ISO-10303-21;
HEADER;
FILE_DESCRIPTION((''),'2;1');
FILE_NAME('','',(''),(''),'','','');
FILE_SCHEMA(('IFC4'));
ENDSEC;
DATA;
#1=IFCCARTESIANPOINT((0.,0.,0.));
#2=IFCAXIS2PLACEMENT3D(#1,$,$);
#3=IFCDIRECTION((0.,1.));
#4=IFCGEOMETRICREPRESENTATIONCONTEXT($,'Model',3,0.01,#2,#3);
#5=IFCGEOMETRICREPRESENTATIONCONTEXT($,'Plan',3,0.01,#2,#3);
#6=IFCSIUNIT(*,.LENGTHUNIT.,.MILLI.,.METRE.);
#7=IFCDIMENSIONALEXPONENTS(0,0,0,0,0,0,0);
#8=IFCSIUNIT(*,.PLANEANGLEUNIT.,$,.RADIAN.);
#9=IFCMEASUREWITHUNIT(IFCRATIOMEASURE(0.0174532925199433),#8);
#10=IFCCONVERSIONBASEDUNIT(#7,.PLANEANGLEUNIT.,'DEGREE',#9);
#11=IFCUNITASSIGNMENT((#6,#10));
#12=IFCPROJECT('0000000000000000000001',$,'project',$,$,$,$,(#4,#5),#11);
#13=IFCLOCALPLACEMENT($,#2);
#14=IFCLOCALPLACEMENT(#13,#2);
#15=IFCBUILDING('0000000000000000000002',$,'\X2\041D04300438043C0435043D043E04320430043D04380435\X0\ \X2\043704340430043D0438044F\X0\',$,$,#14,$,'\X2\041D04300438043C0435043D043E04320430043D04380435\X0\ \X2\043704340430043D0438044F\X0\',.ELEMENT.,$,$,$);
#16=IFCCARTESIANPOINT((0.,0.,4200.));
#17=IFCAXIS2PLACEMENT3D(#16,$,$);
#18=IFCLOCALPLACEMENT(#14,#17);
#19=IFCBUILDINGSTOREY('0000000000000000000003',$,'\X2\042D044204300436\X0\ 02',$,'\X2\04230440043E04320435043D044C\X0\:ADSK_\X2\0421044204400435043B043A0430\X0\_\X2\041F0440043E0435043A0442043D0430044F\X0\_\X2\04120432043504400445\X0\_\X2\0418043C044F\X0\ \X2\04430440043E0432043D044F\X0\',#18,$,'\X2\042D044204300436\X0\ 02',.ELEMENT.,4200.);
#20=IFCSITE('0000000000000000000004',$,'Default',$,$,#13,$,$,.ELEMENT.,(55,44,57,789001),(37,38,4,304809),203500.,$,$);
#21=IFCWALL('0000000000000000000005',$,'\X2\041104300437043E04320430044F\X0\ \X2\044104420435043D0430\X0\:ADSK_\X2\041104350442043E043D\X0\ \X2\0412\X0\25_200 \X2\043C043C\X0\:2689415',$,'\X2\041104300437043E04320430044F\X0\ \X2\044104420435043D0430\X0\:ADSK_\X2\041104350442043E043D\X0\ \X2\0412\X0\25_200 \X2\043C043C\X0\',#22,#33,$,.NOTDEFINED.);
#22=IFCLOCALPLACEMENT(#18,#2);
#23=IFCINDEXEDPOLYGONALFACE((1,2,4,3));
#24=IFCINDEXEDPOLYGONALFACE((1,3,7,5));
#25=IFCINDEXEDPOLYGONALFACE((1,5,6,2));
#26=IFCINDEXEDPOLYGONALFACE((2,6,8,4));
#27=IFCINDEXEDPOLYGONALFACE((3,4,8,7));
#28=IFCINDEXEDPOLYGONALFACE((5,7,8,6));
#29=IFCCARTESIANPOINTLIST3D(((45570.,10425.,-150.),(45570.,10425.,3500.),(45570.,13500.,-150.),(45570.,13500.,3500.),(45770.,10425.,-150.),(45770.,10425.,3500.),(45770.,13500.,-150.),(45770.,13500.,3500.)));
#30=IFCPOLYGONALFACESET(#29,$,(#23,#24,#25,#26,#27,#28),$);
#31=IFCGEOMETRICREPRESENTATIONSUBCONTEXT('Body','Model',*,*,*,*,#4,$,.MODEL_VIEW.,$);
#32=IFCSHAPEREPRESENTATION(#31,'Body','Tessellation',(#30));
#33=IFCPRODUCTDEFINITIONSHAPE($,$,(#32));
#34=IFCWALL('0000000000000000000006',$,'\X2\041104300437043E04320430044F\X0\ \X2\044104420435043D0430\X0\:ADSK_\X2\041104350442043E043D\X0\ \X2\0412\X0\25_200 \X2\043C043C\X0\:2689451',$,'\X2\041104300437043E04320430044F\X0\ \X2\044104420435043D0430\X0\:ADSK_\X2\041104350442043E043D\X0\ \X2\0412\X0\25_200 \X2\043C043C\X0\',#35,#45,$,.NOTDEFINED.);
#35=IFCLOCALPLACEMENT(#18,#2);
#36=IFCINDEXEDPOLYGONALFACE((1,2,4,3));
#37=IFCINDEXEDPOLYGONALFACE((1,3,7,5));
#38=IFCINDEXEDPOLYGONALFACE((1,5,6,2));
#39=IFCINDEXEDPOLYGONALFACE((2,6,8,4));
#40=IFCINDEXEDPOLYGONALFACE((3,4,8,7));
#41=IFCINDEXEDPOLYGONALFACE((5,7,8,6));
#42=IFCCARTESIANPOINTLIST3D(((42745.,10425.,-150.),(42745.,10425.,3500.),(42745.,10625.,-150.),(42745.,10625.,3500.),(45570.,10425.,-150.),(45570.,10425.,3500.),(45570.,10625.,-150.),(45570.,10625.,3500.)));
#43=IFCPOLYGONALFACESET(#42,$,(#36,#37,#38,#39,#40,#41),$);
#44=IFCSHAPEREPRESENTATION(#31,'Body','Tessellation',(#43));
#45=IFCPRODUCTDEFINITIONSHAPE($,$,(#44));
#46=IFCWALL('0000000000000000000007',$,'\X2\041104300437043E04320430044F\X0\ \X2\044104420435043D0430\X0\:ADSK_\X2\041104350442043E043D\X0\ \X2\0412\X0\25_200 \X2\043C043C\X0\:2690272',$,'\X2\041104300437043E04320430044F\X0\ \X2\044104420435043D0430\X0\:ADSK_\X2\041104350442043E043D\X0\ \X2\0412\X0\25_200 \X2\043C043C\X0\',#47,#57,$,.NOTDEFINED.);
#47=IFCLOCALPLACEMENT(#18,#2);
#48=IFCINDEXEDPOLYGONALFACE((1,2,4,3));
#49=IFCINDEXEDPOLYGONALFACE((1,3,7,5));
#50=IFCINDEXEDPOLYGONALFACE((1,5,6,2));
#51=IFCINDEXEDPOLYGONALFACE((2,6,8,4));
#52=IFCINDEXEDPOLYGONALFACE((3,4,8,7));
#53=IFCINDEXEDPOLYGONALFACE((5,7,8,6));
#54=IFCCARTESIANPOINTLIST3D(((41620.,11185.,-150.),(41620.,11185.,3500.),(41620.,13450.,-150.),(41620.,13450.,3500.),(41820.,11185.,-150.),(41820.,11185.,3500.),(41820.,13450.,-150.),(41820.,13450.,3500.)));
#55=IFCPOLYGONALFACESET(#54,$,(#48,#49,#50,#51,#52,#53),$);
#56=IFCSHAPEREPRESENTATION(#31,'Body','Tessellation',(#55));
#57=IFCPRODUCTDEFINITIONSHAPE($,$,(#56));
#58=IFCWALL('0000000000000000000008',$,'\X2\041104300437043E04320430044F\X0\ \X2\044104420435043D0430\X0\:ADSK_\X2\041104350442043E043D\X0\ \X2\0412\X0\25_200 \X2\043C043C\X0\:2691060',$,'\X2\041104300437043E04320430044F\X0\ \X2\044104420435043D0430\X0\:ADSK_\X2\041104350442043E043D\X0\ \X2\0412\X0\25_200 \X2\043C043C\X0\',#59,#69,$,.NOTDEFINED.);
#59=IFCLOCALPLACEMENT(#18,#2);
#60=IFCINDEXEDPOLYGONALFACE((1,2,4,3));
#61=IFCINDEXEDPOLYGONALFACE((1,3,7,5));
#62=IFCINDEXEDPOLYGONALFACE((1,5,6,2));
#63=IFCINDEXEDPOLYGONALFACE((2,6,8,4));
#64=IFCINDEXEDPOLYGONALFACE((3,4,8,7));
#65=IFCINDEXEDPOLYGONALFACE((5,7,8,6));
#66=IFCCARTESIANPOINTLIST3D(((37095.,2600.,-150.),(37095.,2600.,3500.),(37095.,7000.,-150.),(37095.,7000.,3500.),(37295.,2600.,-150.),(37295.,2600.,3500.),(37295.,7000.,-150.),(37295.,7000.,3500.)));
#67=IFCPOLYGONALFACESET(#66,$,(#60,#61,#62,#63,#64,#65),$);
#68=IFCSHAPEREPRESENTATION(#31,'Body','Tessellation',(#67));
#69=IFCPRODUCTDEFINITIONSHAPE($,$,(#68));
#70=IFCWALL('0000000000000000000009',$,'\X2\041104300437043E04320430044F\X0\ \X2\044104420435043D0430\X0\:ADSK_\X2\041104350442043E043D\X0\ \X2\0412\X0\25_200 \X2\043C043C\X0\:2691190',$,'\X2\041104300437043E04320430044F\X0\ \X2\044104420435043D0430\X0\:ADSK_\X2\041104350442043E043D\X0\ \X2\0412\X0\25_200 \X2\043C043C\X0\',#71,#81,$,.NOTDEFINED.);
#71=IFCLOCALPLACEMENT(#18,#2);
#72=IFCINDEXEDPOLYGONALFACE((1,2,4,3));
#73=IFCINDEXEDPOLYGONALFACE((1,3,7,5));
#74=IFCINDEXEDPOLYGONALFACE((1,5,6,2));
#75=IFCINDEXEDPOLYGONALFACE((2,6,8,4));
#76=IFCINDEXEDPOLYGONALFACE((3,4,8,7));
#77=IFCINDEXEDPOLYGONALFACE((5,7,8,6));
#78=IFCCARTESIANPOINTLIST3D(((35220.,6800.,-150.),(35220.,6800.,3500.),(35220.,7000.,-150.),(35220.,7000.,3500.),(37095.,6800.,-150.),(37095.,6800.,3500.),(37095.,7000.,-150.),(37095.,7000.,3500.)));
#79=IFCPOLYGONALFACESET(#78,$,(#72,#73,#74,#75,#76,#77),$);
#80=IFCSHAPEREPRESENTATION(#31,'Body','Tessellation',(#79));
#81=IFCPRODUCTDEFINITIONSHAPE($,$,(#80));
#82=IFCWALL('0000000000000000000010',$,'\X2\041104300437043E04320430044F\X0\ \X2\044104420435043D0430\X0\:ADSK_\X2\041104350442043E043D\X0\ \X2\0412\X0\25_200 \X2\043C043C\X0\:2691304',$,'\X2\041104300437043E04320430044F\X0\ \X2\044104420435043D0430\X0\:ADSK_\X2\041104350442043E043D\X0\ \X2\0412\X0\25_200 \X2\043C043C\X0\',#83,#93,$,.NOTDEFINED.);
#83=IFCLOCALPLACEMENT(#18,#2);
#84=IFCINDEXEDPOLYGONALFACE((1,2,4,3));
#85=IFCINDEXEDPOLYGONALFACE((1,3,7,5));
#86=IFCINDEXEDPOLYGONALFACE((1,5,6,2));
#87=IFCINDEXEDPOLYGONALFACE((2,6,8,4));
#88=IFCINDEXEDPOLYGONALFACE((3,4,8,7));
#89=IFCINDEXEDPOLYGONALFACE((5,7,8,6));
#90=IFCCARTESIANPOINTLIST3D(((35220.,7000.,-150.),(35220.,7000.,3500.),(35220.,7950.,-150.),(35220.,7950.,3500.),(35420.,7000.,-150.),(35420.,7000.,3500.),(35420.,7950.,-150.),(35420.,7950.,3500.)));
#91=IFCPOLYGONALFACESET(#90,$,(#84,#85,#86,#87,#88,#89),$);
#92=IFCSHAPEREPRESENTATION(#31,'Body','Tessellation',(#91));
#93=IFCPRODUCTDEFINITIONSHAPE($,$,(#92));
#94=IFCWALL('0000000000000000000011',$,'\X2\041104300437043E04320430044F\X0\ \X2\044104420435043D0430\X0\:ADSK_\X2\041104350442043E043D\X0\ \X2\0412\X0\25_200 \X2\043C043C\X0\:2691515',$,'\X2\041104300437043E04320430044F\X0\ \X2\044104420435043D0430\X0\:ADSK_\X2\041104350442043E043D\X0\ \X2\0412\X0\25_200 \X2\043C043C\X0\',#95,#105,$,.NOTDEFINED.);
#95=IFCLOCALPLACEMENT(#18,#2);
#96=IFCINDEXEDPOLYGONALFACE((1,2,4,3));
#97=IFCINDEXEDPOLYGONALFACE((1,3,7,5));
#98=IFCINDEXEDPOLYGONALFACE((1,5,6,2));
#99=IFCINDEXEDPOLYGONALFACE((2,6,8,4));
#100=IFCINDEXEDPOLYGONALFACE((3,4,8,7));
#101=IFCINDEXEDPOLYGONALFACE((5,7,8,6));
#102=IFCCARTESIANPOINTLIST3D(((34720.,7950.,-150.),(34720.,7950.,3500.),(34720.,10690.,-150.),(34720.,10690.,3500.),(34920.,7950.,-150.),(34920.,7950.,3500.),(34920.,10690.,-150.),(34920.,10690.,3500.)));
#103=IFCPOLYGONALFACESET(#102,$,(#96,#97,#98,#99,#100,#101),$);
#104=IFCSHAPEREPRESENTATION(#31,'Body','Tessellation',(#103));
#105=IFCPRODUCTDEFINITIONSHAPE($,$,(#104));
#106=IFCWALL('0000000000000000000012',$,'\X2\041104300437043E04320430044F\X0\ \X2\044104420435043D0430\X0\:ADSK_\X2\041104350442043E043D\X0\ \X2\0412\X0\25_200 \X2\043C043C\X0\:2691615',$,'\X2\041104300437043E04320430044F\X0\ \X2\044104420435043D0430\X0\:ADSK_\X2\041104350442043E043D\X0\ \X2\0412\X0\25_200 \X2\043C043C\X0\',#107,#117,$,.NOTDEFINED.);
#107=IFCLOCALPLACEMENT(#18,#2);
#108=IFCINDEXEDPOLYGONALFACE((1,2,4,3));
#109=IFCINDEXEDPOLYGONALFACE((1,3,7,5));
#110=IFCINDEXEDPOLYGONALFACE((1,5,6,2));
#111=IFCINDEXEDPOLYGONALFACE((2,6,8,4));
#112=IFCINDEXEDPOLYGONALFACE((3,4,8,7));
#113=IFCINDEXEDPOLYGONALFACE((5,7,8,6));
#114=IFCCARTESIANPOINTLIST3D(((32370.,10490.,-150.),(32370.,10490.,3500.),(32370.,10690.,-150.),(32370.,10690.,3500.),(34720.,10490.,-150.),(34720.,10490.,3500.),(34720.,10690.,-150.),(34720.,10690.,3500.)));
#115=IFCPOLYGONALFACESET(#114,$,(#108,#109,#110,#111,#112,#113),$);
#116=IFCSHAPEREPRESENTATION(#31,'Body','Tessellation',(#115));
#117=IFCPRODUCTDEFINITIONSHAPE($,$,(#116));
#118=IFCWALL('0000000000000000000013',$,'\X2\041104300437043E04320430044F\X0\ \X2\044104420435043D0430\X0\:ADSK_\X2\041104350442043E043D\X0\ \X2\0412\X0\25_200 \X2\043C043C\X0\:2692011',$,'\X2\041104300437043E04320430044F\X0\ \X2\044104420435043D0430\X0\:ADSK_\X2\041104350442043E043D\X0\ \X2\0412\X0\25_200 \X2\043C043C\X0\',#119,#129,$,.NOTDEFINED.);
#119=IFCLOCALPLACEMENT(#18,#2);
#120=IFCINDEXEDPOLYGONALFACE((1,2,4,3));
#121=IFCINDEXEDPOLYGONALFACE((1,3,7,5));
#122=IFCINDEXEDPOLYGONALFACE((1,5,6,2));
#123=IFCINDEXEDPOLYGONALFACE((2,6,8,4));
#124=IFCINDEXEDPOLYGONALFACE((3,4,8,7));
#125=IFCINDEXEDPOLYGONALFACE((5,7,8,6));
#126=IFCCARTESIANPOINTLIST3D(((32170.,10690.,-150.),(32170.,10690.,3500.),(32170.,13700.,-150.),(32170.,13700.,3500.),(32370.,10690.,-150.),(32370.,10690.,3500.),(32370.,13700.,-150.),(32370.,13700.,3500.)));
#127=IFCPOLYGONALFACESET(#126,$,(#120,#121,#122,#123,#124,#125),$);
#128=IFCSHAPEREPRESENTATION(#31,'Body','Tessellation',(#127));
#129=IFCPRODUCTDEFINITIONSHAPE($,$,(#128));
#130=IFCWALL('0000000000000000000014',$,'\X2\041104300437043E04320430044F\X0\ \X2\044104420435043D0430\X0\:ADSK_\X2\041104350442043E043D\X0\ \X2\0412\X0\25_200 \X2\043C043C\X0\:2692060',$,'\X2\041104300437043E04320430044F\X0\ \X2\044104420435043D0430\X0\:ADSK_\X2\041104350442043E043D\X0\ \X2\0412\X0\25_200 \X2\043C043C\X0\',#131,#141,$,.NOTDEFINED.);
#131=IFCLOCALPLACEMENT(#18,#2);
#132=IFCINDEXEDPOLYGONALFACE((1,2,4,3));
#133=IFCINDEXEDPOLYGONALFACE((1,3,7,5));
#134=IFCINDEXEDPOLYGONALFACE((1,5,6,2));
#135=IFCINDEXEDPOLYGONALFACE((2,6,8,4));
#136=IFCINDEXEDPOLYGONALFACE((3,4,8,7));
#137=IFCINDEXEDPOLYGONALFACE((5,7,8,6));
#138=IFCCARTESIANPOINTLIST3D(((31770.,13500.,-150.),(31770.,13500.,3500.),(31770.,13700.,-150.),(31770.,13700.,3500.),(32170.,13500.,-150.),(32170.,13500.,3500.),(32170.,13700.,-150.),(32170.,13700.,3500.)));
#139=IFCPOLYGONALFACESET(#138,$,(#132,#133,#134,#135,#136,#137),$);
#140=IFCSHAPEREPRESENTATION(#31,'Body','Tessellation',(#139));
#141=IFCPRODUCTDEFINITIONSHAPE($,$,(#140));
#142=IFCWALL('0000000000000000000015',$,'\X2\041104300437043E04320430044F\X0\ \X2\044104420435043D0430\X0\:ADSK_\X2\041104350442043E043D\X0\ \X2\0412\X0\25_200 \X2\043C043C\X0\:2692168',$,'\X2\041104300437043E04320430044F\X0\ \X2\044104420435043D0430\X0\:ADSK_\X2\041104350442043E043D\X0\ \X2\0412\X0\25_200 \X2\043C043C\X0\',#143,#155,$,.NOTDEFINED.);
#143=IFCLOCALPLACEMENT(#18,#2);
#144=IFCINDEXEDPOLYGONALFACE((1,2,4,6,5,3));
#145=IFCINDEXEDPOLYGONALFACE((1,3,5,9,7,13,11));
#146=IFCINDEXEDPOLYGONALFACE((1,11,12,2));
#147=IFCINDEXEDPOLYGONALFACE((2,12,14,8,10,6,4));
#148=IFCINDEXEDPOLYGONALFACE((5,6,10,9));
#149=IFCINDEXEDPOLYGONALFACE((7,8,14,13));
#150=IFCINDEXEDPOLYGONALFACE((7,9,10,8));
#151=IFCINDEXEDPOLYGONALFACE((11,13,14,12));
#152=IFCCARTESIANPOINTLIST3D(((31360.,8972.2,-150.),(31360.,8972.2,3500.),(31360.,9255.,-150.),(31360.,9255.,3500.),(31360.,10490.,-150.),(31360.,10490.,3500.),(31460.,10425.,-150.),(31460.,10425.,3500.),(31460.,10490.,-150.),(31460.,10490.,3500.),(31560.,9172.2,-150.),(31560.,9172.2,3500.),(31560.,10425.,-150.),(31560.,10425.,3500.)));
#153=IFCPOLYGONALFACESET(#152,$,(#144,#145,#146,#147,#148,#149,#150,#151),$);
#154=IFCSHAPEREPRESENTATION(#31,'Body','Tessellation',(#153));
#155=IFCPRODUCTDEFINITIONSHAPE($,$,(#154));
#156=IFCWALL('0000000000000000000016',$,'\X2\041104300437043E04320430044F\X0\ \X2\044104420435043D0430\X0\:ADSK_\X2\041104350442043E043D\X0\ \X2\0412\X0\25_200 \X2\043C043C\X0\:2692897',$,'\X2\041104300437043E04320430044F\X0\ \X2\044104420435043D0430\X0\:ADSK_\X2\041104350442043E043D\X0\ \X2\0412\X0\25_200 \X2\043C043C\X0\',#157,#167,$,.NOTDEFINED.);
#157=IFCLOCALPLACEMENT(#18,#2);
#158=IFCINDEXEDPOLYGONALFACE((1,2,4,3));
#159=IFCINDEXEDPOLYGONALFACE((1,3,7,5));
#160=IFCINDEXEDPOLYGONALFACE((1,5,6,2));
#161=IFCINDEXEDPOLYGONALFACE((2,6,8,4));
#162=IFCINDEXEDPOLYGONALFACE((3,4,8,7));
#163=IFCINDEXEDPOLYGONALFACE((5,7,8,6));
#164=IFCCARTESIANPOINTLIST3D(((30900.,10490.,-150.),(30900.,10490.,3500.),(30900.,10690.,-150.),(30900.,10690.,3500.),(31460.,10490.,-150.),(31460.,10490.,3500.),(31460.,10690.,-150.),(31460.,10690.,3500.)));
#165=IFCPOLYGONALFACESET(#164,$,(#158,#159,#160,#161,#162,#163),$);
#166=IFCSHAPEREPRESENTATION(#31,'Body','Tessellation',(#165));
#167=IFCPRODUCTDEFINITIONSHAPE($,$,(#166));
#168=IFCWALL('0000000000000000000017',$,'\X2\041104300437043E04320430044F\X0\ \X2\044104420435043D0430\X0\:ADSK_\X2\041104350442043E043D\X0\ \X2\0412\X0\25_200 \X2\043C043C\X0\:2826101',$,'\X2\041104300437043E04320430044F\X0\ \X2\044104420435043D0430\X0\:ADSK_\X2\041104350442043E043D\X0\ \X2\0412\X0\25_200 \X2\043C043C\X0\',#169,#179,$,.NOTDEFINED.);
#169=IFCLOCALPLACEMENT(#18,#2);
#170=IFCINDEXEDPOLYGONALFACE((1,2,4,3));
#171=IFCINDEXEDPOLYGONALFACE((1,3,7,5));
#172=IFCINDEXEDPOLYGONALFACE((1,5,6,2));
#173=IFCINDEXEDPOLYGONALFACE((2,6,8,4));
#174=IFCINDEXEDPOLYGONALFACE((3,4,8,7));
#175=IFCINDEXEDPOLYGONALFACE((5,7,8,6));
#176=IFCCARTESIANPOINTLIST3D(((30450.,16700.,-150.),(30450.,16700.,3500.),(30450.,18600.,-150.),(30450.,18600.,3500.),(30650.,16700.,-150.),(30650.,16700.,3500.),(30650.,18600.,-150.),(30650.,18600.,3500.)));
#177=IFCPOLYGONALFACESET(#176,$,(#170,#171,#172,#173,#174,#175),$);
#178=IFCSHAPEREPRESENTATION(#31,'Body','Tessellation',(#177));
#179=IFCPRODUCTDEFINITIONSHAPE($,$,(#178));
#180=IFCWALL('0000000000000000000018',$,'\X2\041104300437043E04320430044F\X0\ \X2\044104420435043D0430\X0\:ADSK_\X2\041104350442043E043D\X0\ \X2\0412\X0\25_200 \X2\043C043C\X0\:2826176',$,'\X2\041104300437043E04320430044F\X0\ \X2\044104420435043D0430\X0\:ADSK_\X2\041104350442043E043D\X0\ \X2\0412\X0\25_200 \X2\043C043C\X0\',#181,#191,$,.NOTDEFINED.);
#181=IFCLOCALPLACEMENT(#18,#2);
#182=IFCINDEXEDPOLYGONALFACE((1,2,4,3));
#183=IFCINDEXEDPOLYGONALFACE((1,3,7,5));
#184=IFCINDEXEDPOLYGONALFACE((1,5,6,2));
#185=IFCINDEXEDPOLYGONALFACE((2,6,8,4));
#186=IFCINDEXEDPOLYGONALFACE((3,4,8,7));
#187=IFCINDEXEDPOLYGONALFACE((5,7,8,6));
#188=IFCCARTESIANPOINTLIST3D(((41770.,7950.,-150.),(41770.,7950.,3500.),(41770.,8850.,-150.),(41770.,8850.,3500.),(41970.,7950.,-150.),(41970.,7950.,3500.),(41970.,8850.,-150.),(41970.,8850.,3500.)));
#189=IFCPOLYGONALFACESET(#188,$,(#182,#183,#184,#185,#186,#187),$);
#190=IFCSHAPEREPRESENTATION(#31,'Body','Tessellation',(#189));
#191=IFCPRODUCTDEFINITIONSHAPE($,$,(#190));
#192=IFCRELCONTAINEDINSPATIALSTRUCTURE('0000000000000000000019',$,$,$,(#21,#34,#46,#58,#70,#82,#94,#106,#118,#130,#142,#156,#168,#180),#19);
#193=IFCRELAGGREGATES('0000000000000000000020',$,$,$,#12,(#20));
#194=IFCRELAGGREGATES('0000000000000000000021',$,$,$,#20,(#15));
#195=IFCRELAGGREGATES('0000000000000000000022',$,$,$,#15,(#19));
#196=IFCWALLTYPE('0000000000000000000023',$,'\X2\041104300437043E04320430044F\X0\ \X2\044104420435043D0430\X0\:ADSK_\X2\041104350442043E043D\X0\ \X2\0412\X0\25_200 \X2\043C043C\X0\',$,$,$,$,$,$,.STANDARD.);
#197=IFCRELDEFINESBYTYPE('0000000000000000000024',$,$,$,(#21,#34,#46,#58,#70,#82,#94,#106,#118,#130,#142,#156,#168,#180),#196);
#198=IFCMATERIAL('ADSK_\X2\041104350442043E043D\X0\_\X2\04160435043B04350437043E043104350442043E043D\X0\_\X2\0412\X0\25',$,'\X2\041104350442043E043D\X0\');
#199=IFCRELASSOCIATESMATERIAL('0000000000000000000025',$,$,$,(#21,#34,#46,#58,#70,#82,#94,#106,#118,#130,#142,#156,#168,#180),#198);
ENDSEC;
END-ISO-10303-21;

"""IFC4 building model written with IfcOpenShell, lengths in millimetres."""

from ifc_helpers import new_model, entity, si_unit, converted_unit, direction, frame, origin, place, context, subcontext, project, spatial, indexed_curve, outline, extrude, material, type_object, element, save


model = new_model("IFC4")

# Units and contexts
model_context = context("Model", 3, precision=0.01, world=origin(), true_north=direction((0.0, 1.0)))
plan_context = context("Plan", 3, precision=0.01, world=origin(), true_north=direction((0.0, 1.0)))
body_context = subcontext(model_context, "Body", "Model", "MODEL_VIEW")
ifc_project = project(units=[si_unit("LENGTHUNIT", "METRE", prefix="MILLI"), converted_unit("PLANEANGLEUNIT", "DEGREE", entity("IfcRatioMeasure", 0.0174532925199433), si_unit("PLANEANGLEUNIT", "RADIAN"), dimensions=[0, 0, 0, 0, 0, 0, 0])], contexts=[model_context, plan_context])

# Site, building, storey
site_placement = place(None, origin())
site = spatial("IfcSite", under=ifc_project, at=site_placement, Name="Default", CompositionType="ELEMENT", RefLatitude=(55, 44, 57, 789001), RefLongitude=(37, 38, 4, 304809), RefElevation=203500.0)
building_placement = place(site_placement, origin())
building = spatial("IfcBuilding", under=site, at=building_placement, Name="Наименование здания", LongName="Наименование здания", CompositionType="ELEMENT")
storey_placement = place(building_placement, frame((0.0, 0.0, 4200.0)))
storey = spatial("IfcBuildingStorey", under=building, at=storey_placement, Name="Этаж 02", ObjectType="Уровень:ADSK_Стрелка_Проектная_Вверх_Имя уровня", LongName="Этаж 02", CompositionType="ELEMENT", Elevation=4200.0)

# Walls
ifc_material = material(Name="ADSK_Бетон_Железобетон_В25", Category="Бетон")
wall_type_1 = type_object("IfcWallType", Name="Базовая стена:ADSK_Бетон В25_200 мм", PredefinedType="STANDARD")
wall_1_placement = place(storey_placement, frame((45670.0, 13500.0, -150.0), z_axis=(0.0, 0.0, 1.0), x_axis=(0.0, -1.0, 0.0)))
element("IfcWall", 1, at=wall_1_placement, inside=storey, type_object=wall_type_1, material=ifc_material, Name="Базовая стена:ADSK_Бетон В25_200 мм:2689415", ObjectType="Базовая стена:ADSK_Бетон В25_200 мм", PredefinedType="NOTDEFINED", context=body_context, shape_type="SweptSolid", body=[
    extrude(outline(indexed_curve([(3075.0, 100.0), (0.0, 100.0), (0.0, -100.0), (3075.0, -100.0), (3075.0, 100.0)], self_intersect=False)), origin(), (0.0, 0.0, 1.0), 3650.0),
])
wall_2_placement = place(storey_placement, frame((45570.0, 10525.0, -150.0), z_axis=(0.0, 0.0, 1.0), x_axis=(-1.0, 0.0, 0.0)))
element("IfcWall", 2, at=wall_2_placement, inside=storey, type_object=wall_type_1, material=ifc_material, Name="Базовая стена:ADSK_Бетон В25_200 мм:2689451", ObjectType="Базовая стена:ADSK_Бетон В25_200 мм", PredefinedType="NOTDEFINED", context=body_context, shape_type="SweptSolid", body=[
    extrude(outline(indexed_curve([(2825.0, 100.0), (0.0, 100.0), (0.0, -100.0), (2825.0, -100.0), (2825.0, 100.0)], self_intersect=False)), origin(), (0.0, 0.0, 1.0), 3650.0),
])
wall_3_placement = place(storey_placement, frame((41720.0, 13450.0, -150.0), z_axis=(0.0, 0.0, 1.0), x_axis=(0.0, -1.0, 0.0)))
element("IfcWall", 3, at=wall_3_placement, inside=storey, type_object=wall_type_1, material=ifc_material, Name="Базовая стена:ADSK_Бетон В25_200 мм:2690272", ObjectType="Базовая стена:ADSK_Бетон В25_200 мм", PredefinedType="NOTDEFINED", context=body_context, shape_type="SweptSolid", body=[
    extrude(outline(indexed_curve([(2265.0, 100.0), (0.0, 100.0), (0.0, -100.0), (2265.0, -100.0), (2265.0, 100.0)], self_intersect=False)), origin(), (0.0, 0.0, 1.0), 3650.0),
])
wall_4_placement = place(storey_placement, frame((37195.0, 2600.0, -150.0), z_axis=(0.0, 0.0, 1.0), x_axis=(0.0, 1.0, 0.0)))
element("IfcWall", 4, at=wall_4_placement, inside=storey, type_object=wall_type_1, material=ifc_material, Name="Базовая стена:ADSK_Бетон В25_200 мм:2691060", ObjectType="Базовая стена:ADSK_Бетон В25_200 мм", PredefinedType="NOTDEFINED", context=body_context, shape_type="SweptSolid", body=[
    extrude(outline(indexed_curve([(4400.0, 100.0), (0.0, 100.0), (0.0, -100.0), (4400.0, -100.0), (4400.0, 100.0)], self_intersect=False)), origin(), (0.0, 0.0, 1.0), 3650.0),
])
wall_5_placement = place(storey_placement, frame((37095.0, 6900.0, -150.0), z_axis=(0.0, 0.0, 1.0), x_axis=(-1.0, 0.0, 0.0)))
element("IfcWall", 5, at=wall_5_placement, inside=storey, type_object=wall_type_1, material=ifc_material, Name="Базовая стена:ADSK_Бетон В25_200 мм:2691190", ObjectType="Базовая стена:ADSK_Бетон В25_200 мм", PredefinedType="NOTDEFINED", context=body_context, shape_type="SweptSolid", body=[
    extrude(outline(indexed_curve([(1875.0, 100.0), (0.0, 100.0), (0.0, -100.0), (1875.0, -100.0), (1875.0, 100.0)], self_intersect=False)), origin(), (0.0, 0.0, 1.0), 3650.0),
])
wall_6_placement = place(storey_placement, frame((35320.0, 7000.0, -150.0), z_axis=(0.0, 0.0, 1.0), x_axis=(0.0, 1.0, 0.0)))
element("IfcWall", 6, at=wall_6_placement, inside=storey, type_object=wall_type_1, material=ifc_material, Name="Базовая стена:ADSK_Бетон В25_200 мм:2691304", ObjectType="Базовая стена:ADSK_Бетон В25_200 мм", PredefinedType="NOTDEFINED", context=body_context, shape_type="SweptSolid", body=[
    extrude(outline(indexed_curve([(950.0, 100.0), (0.0, 100.0), (0.0, -100.0), (950.0, -100.0), (950.0, 100.0)], self_intersect=False)), origin(), (0.0, 0.0, 1.0), 3650.0),
])
wall_7_placement = place(storey_placement, frame((34820.0, 7950.0, -150.0), z_axis=(0.0, 0.0, 1.0), x_axis=(0.0, 1.0, 0.0)))
element("IfcWall", 7, at=wall_7_placement, inside=storey, type_object=wall_type_1, material=ifc_material, Name="Базовая стена:ADSK_Бетон В25_200 мм:2691515", ObjectType="Базовая стена:ADSK_Бетон В25_200 мм", PredefinedType="NOTDEFINED", context=body_context, shape_type="SweptSolid", body=[
    extrude(outline(indexed_curve([(2740.0, 100.0), (0.0, 100.0), (0.0, -100.0), (2740.0, -100.0), (2740.0, 100.0)], self_intersect=False)), origin(), (0.0, 0.0, 1.0), 3650.0),
])
wall_8_placement = place(storey_placement, frame((34720.0, 10590.0, -150.0), z_axis=(0.0, 0.0, 1.0), x_axis=(-1.0, 0.0, 0.0)))
element("IfcWall", 8, at=wall_8_placement, inside=storey, type_object=wall_type_1, material=ifc_material, Name="Базовая стена:ADSK_Бетон В25_200 мм:2691615", ObjectType="Базовая стена:ADSK_Бетон В25_200 мм", PredefinedType="NOTDEFINED", context=body_context, shape_type="SweptSolid", body=[
    extrude(outline(indexed_curve([(2350.0, 100.0), (0.0, 100.0), (0.0, -100.0), (2350.0, -100.0), (2350.0, 100.0)], self_intersect=False)), origin(), (0.0, 0.0, 1.0), 3650.0),
])
wall_9_placement = place(storey_placement, frame((32270.0, 10690.0, -150.0), z_axis=(0.0, 0.0, 1.0), x_axis=(0.0, 1.0, 0.0)))
element("IfcWall", 9, at=wall_9_placement, inside=storey, type_object=wall_type_1, material=ifc_material, Name="Базовая стена:ADSK_Бетон В25_200 мм:2692011", ObjectType="Базовая стена:ADSK_Бетон В25_200 мм", PredefinedType="NOTDEFINED", context=body_context, shape_type="SweptSolid", body=[
    extrude(outline(indexed_curve([(3010.0, 100.0), (0.0, 100.0), (0.0, -100.0), (3010.0, -100.0), (3010.0, 100.0)], self_intersect=False)), origin(), (0.0, 0.0, 1.0), 3650.0),
])
wall_10_placement = place(storey_placement, frame((32170.0, 13600.0, -150.0), z_axis=(0.0, 0.0, 1.0), x_axis=(-1.0, 0.0, 0.0)))
element("IfcWall", 10, at=wall_10_placement, inside=storey, type_object=wall_type_1, material=ifc_material, Name="Базовая стена:ADSK_Бетон В25_200 мм:2692060", ObjectType="Базовая стена:ADSK_Бетон В25_200 мм", PredefinedType="NOTDEFINED", context=body_context, shape_type="SweptSolid", body=[
    extrude(outline(indexed_curve([(400.0, 100.0), (0.0, 100.0), (0.0, -100.0), (400.0, -100.0), (400.0, 100.0)], self_intersect=False)), origin(), (0.0, 0.0, 1.0), 3650.0),
])
wall_11_placement = place(storey_placement, frame((31460.0, 10490.0, -150.0), z_axis=(0.0, 0.0, 1.0), x_axis=(0.0, -1.0, 0.0)))
element("IfcWall", 11, at=wall_11_placement, inside=storey, type_object=wall_type_1, material=ifc_material, Name="Базовая стена:ADSK_Бетон В25_200 мм:2692168", ObjectType="Базовая стена:ADSK_Бетон В25_200 мм", PredefinedType="NOTDEFINED", context=body_context, shape_type="SweptSolid", body=[
    extrude(outline(indexed_curve([(1517.8, -100.0), (1317.8, 100.0), (65.0, 100.0), (65.0, 0.0), (0.0, 0.0), (0.0, -100.0), (1235.0, -100.0), (1517.8, -100.0)], self_intersect=False)), origin(), (0.0, 0.0, 1.0), 3650.0),
])
wall_12_placement = place(storey_placement, frame((31460.0, 10590.0, -150.0), z_axis=(0.0, 0.0, 1.0), x_axis=(-1.0, 0.0, 0.0)))
element("IfcWall", 12, at=wall_12_placement, inside=storey, type_object=wall_type_1, material=ifc_material, Name="Базовая стена:ADSK_Бетон В25_200 мм:2692897", ObjectType="Базовая стена:ADSK_Бетон В25_200 мм", PredefinedType="NOTDEFINED", context=body_context, shape_type="SweptSolid", body=[
    extrude(outline(indexed_curve([(560.0, 100.0), (0.0, 100.0), (0.0, -100.0), (560.0, -100.0), (560.0, 100.0)], self_intersect=False)), origin(), (0.0, 0.0, 1.0), 3650.0),
])
wall_13_placement = place(storey_placement, frame((30550.0, 18600.0, -150.0), z_axis=(0.0, 0.0, 1.0), x_axis=(0.0, -1.0, 0.0)))
element("IfcWall", 13, at=wall_13_placement, inside=storey, type_object=wall_type_1, material=ifc_material, Name="Базовая стена:ADSK_Бетон В25_200 мм:2826101", ObjectType="Базовая стена:ADSK_Бетон В25_200 мм", PredefinedType="NOTDEFINED", context=body_context, shape_type="SweptSolid", body=[
    extrude(outline(indexed_curve([(1900.0, 100.0), (0.0, 100.0), (0.0, -100.0), (1900.0, -100.0), (1900.0, 100.0)], self_intersect=False)), origin(), (0.0, 0.0, 1.0), 3650.0),
])
wall_14_placement = place(storey_placement, frame((41870.0, 7950.0, -150.0), z_axis=(0.0, 0.0, 1.0), x_axis=(0.0, 1.0, 0.0)))
element("IfcWall", 14, at=wall_14_placement, inside=storey, type_object=wall_type_1, material=ifc_material, Name="Базовая стена:ADSK_Бетон В25_200 мм:2826176", ObjectType="Базовая стена:ADSK_Бетон В25_200 мм", PredefinedType="NOTDEFINED", context=body_context, shape_type="SweptSolid", body=[
    extrude(outline(indexed_curve([(900.0, 100.0), (0.0, 100.0), (0.0, -100.0), (900.0, -100.0), (900.0, 100.0)], self_intersect=False)), origin(), (0.0, 0.0, 1.0), 3650.0),
])

save(model, "model.ifc")
